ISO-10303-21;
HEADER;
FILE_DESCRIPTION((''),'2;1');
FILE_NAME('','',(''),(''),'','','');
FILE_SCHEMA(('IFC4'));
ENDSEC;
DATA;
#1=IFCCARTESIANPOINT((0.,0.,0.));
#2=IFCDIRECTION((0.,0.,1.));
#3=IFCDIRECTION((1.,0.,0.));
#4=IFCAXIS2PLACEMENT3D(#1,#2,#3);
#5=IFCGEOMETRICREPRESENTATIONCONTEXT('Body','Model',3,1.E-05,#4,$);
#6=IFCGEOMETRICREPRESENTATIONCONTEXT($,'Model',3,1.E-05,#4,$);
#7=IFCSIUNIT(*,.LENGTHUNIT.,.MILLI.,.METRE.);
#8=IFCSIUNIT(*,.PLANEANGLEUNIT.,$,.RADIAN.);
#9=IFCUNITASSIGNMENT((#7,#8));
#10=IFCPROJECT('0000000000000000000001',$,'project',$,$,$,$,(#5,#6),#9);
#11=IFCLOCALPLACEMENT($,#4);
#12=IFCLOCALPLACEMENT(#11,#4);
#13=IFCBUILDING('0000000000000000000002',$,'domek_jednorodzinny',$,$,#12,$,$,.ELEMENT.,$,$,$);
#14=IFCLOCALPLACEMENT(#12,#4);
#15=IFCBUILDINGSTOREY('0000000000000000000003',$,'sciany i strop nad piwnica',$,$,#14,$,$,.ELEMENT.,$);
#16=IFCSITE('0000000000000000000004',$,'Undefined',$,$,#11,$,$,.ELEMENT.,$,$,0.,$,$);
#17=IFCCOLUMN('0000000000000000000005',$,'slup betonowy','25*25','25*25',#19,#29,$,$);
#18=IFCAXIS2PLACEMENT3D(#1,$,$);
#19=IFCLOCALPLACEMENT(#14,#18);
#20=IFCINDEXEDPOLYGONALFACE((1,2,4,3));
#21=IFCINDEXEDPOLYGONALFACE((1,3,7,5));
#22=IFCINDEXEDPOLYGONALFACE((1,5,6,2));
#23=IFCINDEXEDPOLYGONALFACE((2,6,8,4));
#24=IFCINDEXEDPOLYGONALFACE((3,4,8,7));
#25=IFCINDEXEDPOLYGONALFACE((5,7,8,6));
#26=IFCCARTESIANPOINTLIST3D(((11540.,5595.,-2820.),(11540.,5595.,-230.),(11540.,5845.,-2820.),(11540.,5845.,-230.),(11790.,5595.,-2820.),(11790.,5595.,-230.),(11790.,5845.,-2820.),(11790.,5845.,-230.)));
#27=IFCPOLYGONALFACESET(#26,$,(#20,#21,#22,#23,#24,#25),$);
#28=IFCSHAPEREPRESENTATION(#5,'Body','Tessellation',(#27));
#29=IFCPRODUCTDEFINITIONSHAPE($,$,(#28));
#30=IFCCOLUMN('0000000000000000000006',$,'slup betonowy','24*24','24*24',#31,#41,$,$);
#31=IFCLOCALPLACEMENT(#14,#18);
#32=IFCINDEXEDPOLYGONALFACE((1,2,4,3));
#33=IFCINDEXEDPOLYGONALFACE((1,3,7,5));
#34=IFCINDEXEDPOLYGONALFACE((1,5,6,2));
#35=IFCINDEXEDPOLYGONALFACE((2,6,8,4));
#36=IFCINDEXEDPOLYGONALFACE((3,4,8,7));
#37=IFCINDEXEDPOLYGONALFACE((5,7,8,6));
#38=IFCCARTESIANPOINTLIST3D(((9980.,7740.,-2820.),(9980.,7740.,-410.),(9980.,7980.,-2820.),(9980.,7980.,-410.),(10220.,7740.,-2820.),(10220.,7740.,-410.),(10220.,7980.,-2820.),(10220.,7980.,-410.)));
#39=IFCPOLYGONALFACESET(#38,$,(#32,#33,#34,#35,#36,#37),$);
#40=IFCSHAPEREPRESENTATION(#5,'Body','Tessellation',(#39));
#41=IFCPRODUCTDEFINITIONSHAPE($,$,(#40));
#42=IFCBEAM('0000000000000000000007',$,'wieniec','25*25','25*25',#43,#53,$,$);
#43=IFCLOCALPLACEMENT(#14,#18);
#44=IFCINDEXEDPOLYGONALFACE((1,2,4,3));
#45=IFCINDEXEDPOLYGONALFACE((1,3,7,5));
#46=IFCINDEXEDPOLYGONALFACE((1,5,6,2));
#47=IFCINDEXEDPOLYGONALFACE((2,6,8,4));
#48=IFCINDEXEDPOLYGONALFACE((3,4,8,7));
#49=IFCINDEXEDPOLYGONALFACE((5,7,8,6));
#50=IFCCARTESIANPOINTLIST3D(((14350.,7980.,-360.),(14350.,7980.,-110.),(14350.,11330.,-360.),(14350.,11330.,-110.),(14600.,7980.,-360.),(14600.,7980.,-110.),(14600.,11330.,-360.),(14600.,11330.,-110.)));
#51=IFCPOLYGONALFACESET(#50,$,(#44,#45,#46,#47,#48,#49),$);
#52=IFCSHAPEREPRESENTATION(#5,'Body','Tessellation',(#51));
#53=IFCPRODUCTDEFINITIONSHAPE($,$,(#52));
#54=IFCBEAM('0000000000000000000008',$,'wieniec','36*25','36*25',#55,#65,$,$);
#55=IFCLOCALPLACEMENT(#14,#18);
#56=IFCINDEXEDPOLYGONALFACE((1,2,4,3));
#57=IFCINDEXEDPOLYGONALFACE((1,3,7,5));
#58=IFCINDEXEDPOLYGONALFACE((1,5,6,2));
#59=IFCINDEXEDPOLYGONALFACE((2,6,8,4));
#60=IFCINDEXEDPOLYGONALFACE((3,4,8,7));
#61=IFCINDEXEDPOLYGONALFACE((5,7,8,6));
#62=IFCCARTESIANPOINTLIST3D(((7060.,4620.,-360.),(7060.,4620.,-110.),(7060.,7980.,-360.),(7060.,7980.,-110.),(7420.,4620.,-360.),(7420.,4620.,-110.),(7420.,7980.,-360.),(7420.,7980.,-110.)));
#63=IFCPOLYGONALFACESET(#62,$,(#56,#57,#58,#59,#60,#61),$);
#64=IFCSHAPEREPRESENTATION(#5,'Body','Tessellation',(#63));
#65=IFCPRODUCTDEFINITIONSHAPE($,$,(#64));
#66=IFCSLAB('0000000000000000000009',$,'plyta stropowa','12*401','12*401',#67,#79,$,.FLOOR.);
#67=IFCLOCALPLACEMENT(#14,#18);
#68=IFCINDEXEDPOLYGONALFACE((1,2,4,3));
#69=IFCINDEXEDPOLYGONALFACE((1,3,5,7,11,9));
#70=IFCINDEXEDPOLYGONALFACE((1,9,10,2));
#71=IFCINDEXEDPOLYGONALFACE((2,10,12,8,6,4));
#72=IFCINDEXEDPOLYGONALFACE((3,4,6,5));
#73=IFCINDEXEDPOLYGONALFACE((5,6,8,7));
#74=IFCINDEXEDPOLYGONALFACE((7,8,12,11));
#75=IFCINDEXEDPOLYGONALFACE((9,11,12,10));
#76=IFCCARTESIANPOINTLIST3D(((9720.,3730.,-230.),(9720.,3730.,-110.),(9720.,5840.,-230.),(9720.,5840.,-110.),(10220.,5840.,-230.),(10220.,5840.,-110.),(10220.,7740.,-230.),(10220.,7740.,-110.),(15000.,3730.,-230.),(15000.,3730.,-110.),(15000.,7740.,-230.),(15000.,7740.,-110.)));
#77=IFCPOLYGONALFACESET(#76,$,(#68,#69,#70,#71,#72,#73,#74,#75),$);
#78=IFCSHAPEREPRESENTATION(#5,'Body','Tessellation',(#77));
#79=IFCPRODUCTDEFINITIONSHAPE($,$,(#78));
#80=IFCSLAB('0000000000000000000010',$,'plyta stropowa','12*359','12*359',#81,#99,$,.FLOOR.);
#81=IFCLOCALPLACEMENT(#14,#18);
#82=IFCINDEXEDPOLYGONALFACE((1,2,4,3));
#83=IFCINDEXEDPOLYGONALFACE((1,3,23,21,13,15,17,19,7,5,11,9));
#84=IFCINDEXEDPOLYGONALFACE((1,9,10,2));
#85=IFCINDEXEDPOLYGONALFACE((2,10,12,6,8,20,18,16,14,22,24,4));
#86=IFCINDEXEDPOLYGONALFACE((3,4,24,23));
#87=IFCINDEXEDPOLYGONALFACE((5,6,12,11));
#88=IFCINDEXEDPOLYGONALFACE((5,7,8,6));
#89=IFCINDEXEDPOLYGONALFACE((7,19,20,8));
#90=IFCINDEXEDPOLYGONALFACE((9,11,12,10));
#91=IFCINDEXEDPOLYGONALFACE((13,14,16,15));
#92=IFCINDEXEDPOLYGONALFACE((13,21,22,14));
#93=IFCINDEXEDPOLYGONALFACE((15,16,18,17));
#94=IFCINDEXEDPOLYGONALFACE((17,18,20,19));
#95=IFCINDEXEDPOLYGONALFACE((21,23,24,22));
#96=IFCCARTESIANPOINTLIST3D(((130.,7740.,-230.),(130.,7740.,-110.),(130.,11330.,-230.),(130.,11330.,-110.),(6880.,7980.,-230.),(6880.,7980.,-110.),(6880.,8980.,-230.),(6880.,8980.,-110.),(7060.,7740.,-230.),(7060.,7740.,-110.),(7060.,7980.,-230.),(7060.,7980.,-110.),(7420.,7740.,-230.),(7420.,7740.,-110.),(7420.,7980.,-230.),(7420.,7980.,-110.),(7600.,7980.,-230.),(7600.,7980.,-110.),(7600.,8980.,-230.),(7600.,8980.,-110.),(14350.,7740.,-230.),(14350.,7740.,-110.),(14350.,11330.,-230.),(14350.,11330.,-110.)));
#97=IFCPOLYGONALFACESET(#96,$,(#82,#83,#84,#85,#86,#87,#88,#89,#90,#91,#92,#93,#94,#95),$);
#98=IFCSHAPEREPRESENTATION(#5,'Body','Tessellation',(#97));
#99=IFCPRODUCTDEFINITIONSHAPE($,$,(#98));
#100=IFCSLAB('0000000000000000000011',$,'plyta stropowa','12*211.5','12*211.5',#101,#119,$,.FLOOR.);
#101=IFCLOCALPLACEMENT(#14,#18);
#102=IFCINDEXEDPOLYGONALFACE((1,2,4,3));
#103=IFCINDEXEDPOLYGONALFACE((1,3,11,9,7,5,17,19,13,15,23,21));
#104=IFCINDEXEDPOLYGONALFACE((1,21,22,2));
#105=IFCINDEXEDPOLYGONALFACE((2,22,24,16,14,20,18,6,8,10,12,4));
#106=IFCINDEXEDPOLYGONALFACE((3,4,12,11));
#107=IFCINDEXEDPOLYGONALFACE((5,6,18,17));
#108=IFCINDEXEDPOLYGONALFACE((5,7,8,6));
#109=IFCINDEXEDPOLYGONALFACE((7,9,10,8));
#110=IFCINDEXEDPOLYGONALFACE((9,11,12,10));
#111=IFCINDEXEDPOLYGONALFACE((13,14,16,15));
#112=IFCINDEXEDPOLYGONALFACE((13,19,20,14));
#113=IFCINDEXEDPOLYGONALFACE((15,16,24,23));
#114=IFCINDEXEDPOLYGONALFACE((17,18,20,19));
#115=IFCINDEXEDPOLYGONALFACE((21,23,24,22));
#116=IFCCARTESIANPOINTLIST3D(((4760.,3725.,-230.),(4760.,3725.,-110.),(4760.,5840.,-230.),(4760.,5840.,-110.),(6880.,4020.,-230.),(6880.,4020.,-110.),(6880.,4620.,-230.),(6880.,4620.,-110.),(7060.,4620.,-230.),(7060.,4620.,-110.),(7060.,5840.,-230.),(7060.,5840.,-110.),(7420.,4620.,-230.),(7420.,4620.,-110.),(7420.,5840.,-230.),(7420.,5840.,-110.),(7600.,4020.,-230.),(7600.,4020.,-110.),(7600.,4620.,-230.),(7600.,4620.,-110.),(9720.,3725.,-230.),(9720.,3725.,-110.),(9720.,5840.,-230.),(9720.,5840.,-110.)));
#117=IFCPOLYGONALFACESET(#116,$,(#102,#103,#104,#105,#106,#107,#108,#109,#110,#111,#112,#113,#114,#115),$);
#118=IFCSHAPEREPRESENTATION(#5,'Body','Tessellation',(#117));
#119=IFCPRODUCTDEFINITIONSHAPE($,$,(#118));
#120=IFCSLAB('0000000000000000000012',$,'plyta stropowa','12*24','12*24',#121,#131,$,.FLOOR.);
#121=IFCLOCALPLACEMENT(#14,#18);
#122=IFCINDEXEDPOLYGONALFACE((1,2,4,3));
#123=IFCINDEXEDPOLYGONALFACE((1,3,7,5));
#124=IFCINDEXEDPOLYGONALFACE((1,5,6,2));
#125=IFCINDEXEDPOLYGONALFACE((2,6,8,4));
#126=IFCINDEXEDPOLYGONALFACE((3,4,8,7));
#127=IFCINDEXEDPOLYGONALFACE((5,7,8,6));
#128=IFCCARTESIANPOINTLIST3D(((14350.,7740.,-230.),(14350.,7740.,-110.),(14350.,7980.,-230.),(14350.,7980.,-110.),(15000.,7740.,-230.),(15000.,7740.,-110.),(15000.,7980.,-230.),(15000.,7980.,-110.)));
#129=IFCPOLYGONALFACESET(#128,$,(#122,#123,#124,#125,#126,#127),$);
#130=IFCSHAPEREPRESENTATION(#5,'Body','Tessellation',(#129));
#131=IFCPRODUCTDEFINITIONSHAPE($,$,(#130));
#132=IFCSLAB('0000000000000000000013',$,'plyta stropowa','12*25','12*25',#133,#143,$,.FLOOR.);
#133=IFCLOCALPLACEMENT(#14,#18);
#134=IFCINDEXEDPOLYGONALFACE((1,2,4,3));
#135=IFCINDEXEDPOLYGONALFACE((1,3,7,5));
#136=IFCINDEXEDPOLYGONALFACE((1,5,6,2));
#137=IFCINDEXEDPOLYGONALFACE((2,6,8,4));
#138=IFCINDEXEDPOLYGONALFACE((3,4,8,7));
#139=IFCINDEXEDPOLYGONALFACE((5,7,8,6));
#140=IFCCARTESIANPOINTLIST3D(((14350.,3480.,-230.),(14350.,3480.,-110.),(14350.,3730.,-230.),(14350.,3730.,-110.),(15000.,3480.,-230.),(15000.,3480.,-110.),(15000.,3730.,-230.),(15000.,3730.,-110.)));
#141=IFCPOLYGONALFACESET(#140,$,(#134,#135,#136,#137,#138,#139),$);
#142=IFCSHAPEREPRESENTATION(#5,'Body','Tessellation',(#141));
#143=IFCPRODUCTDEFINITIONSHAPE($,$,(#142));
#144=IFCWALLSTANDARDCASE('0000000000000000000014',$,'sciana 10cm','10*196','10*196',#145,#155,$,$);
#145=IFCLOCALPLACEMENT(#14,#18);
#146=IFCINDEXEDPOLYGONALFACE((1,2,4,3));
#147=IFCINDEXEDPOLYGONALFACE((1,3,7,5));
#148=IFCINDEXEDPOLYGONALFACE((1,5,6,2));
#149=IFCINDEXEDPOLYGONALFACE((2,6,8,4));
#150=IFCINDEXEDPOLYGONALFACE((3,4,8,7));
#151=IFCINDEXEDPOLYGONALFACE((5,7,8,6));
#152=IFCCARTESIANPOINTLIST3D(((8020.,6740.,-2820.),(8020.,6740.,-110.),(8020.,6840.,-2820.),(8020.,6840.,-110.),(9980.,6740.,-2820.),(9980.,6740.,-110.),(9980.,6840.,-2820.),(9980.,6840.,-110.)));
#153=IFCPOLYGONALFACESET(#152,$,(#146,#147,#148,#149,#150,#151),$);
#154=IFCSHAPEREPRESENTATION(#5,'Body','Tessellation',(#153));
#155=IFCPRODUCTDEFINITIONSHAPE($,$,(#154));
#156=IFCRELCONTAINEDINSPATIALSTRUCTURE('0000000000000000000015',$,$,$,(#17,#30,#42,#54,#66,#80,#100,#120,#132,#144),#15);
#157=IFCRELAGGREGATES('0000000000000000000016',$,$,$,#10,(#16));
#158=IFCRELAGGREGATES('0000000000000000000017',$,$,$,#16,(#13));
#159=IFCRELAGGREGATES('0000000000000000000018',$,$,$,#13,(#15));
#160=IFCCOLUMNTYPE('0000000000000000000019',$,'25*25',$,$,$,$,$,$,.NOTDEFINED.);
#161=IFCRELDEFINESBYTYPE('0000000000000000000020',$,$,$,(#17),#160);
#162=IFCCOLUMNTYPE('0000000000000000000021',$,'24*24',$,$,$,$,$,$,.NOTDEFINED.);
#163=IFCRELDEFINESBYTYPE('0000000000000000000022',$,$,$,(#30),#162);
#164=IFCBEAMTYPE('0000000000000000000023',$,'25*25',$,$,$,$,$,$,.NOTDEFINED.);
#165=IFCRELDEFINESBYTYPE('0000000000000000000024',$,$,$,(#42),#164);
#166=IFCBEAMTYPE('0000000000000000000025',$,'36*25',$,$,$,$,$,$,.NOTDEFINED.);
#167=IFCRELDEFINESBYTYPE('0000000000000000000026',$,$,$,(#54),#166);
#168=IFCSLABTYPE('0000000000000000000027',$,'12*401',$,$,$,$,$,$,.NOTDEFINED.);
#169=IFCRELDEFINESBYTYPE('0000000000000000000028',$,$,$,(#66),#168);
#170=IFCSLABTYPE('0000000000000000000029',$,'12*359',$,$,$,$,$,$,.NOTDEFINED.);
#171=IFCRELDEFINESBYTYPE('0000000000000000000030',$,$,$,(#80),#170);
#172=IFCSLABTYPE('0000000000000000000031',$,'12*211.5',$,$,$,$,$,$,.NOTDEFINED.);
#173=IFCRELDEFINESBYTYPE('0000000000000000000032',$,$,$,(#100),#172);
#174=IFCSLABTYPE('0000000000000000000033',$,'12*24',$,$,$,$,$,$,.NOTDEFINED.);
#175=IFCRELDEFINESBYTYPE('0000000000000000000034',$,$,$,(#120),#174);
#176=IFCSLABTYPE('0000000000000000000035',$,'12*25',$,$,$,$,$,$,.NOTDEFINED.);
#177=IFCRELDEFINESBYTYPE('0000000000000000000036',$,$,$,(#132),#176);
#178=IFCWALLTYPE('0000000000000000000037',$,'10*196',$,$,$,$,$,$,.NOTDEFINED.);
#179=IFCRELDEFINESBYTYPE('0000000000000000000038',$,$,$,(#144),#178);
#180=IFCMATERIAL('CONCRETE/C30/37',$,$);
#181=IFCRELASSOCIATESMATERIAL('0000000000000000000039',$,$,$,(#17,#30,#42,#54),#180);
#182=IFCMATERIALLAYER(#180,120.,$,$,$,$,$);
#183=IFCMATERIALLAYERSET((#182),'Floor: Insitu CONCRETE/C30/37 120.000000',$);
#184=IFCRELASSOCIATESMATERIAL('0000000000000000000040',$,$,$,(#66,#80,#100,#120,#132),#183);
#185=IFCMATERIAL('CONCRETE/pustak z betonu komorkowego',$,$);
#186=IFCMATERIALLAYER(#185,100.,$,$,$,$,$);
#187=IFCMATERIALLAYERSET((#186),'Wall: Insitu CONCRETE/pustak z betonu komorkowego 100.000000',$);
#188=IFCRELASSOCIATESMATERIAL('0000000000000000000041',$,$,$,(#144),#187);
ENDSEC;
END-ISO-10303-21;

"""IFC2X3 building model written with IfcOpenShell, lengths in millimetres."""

from ifc_helpers import new_model, si_unit, frame, frame_2d, origin_with_axes, origin_2d_with_axis, place, context, project, spatial, polyline, rectangle, outline, extrude, material, layer, layer_set, layer_usage, type_object, element, save


model = new_model("IFC2X3")

# Units and contexts
model_context_1 = context("Model", 3, precision=1e-05, world=origin_with_axes(), identifier="Body")
model_context_2 = context("Model", 3, precision=1e-05, world=origin_with_axes())
ifc_project = project(units=[si_unit("LENGTHUNIT", "METRE", prefix="MILLI"), si_unit("PLANEANGLEUNIT", "RADIAN")], contexts=[model_context_1, model_context_2])

# Site, building, storey
site_placement = place(None, origin_with_axes())
site = spatial("IfcSite", under=ifc_project, at=site_placement, Name="Undefined", CompositionType="ELEMENT", RefElevation=0.0)
building_placement = place(site_placement, origin_with_axes())
building = spatial("IfcBuilding", under=site, at=building_placement, Name="domek_jednorodzinny", CompositionType="ELEMENT")
storey_placement = place(building_placement, origin_with_axes())
storey = spatial("IfcBuildingStorey", under=building, at=storey_placement, Name="sciany i strop nad piwnica", CompositionType="ELEMENT")

# Columns
ifc_material_1 = material(Name="CONCRETE/C30/37")
column_type_1 = type_object("IfcColumnType", Name="25*25", PredefinedType="NOTDEFINED")
column_1_placement = place(storey_placement, frame((11665.0, 5720.0, -2820.0), z_axis=(0.0, 0.0, 1.0), x_axis=(1.0, 0.0, 0.0)))
element("IfcColumn", 1, at=column_1_placement, inside=storey, type_object=column_type_1, material=ifc_material_1, Name="slup betonowy", Description="25*25", ObjectType="25*25", context=model_context_1, shape_type="SweptSolid", body=[
    extrude(rectangle(XDim=250.0, YDim=250.0, at=origin_2d_with_axis()), frame((0.0, 0.0, 2590.0), z_axis=(0.0, 0.000012, -1.0), x_axis=(-1.0, 0.0, 0.0)), (0.0, 0.0, 1.0), 2590.0),
])
column_type_2 = type_object("IfcColumnType", Name="24*24", PredefinedType="NOTDEFINED")
column_2_placement = place(storey_placement, frame((10100.0, 7860.0, -2820.0), z_axis=(0.0, 0.0, 1.0), x_axis=(1.0, 0.0, 0.0)))
element("IfcColumn", 2, at=column_2_placement, inside=storey, type_object=column_type_2, material=ifc_material_1, Name="slup betonowy", Description="24*24", ObjectType="24*24", context=model_context_1, shape_type="SweptSolid", body=[
    extrude(rectangle(XDim=240.0, YDim=240.0, at=origin_2d_with_axis()), frame((0.0, 0.0, 2410.0), z_axis=(0.000001, 0.000001, -1.0), x_axis=(-1.0, 0.0, 0.0)), (0.0, 0.0, 1.0), 2410.0),
])

# Beams
beam_type_1 = type_object("IfcBeamType", Name="25*25", PredefinedType="NOTDEFINED")
beam_1_placement = place(storey_placement, frame((14475.0, 7980.0, -235.0), z_axis=(0.0, 0.0, 1.0), x_axis=(0.0, 1.0, 0.0)))
element("IfcBeam", 3, at=beam_1_placement, inside=storey, type_object=beam_type_1, material=ifc_material_1, Name="wieniec", Description="25*25", ObjectType="25*25", context=model_context_1, shape_type="SweptSolid", body=[
    extrude(rectangle(XDim=250.0, YDim=250.0, at=origin_2d_with_axis()), frame((3350.0, 0.0, 0.0), z_axis=(-1.0, 0.0, 0.0), x_axis=(0.0, -1.0, 0.0)), (0.0, 0.0, 1.0), 3350.0),
])
beam_type_2 = type_object("IfcBeamType", Name="36*25", PredefinedType="NOTDEFINED")
beam_2_placement = place(storey_placement, frame((7240.0, 4620.0, -235.0), z_axis=(0.0, 0.0, 1.0), x_axis=(0.0, 1.0, 0.0)))
element("IfcBeam", 4, at=beam_2_placement, inside=storey, type_object=beam_type_2, material=ifc_material_1, Name="wieniec", Description="36*25", ObjectType="36*25", context=model_context_1, shape_type="SweptSolid", body=[
    extrude(rectangle(XDim=360.0, YDim=250.0, at=origin_2d_with_axis()), frame((3360.0, 0.0, 0.0), z_axis=(-1.0, 0.0, 0.0), x_axis=(0.0, -1.0, 0.0)), (0.0, 0.0, 1.0), 3360.0),
])

# Slab, opening
ifc_layer_1 = layer(ifc_material_1, 120.0)
ifc_layer_set_1 = layer_set([ifc_layer_1], Name="Floor: Insitu CONCRETE/C30/37 120.000000")
ifc_layer_usage_1 = layer_usage(ifc_layer_set_1, "AXIS3", "POSITIVE", -60.0)
slab_type_1 = type_object("IfcSlabType", Name="12*401", PredefinedType="NOTDEFINED")
slab_1_placement = place(storey_placement, frame((15000.0, 7740.0, -170.0), z_axis=(0.0, 0.0, 1.0), x_axis=(-1.0, 0.0, 0.0)))
slab_1 = element("IfcSlab", 5, at=slab_1_placement, inside=storey, type_object=slab_type_1, material=ifc_layer_usage_1, Name="plyta stropowa", Description="12*401", ObjectType="12*401", PredefinedType="FLOOR", context=model_context_1, shape_type="SweptSolid", body=[
    extrude(outline(polyline([(0.0, 0.0), (5280.0, 0.0), (5280.0, 4010.0), (0.0, 4010.0), (0.0, 0.0)])), frame((0.0, 0.0, -60.0), z_axis=(0.0, 0.0, 1.0), x_axis=(1.0, 0.0, 0.0)), (0.0, 0.0, 1.0), 120.0),
])
opening_1_placement = place(storey_placement, frame((15000.0, 7740.0, -170.0), z_axis=(0.0, 0.0, 1.0), x_axis=(-1.0, 0.0, 0.0)))
element("IfcOpeningElement", 6, at=opening_1_placement, cuts=slab_1, ObjectType="Recess", context=model_context_1, shape_type="SweptSolid", body=[
    extrude(outline(polyline([(0.0, 0.0), (500.0, 0.0), (500.0, 1900.0), (0.0, 1900.0), (0.0, 0.0)])), frame((4780.0, 1900.0, 62.5), z_axis=(0.000001, 0.000001, -1.0), x_axis=(1.0, 0.0, 0.0)), (0.0, 0.0, 1.0), 125.0),
])

# Slabs, openings
ifc_layer_usage_2 = layer_usage(ifc_layer_set_1, "AXIS3", "POSITIVE", -60.0)
slab_type_2 = type_object("IfcSlabType", Name="12*359", PredefinedType="NOTDEFINED")
slab_2_placement = place(storey_placement, frame((14350.0, 11330.0, -170.0), z_axis=(0.0, 0.0, 1.0), x_axis=(-1.0, 0.0, 0.0)))
slab_2 = element("IfcSlab", 7, at=slab_2_placement, inside=storey, type_object=slab_type_2, material=ifc_layer_usage_2, Name="plyta stropowa", Description="12*359", ObjectType="12*359", PredefinedType="FLOOR", context=model_context_1, shape_type="SweptSolid", body=[
    extrude(outline(polyline([(0.0, 0.0), (14220.0, 0.0), (14220.0, 3590.0), (0.0, 3590.0), (0.0, 0.0)])), frame((0.0, 0.0, -60.0), z_axis=(0.0, 0.0, 1.0), x_axis=(1.0, 0.0, 0.0)), (0.0, 0.0, 1.0), 120.0),
])
opening_2_placement = place(storey_placement, frame((14350.0, 11330.0, -170.0), z_axis=(0.0, 0.0, 1.0), x_axis=(-1.0, 0.0, 0.0)))
element("IfcOpeningElement", 8, at=opening_2_placement, cuts=slab_2, ObjectType="Recess", context=model_context_1, shape_type="SweptSolid", body=[
    extrude(outline(polyline([(0.0, 0.0), (1000.0, 0.0), (1000.0, 720.0), (0.0, 720.0), (0.0, 0.0)])), frame((6750.0, 2350.0, 62.5), z_axis=(0.000001, 0.000001, -1.0), x_axis=(0.0, 1.0, 0.0)), (0.0, 0.0, 1.0), 125.0),
])
opening_3_placement = place(storey_placement, frame((14350.0, 11330.0, -170.0), z_axis=(0.0, 0.0, 1.0), x_axis=(-1.0, 0.0, 0.0)))
element("IfcOpeningElement", 9, at=opening_3_placement, cuts=slab_2, ObjectType="Recess", context=model_context_1, shape_type="SweptSolid", body=[
    extrude(outline(polyline([(0.0, 0.0), (290.0, 0.0), (290.0, 360.0), (0.0, 360.0), (0.0, 0.0)])), frame((7290.0, 3610.0, 112.5), z_axis=(0.000001, 0.000001, -1.0), x_axis=(0.0, -1.0, 0.0)), (0.0, 0.0, 1.0), 225.0),
])
ifc_layer_usage_3 = layer_usage(ifc_layer_set_1, "AXIS3", "POSITIVE", -60.0)
slab_type_3 = type_object("IfcSlabType", Name="12*211.5", PredefinedType="NOTDEFINED")
slab_3_placement = place(storey_placement, frame((9720.0, 5840.0, -170.0), z_axis=(0.0, 0.0, 1.0), x_axis=(-1.0, 0.0, 0.0)))
slab_3 = element("IfcSlab", 10, at=slab_3_placement, inside=storey, type_object=slab_type_3, material=ifc_layer_usage_3, Name="plyta stropowa", Description="12*211.5", ObjectType="12*211.5", PredefinedType="FLOOR", context=model_context_1, shape_type="SweptSolid", body=[
    extrude(outline(polyline([(0.0, 0.0), (4960.0, 0.0), (4960.0, 2115.0), (0.0, 2115.0), (0.0, 0.0)])), frame((0.0, 0.0, -60.0), z_axis=(0.0, 0.0, 1.0), x_axis=(1.0, 0.0, 0.0)), (0.0, 0.0, 1.0), 120.0),
])
opening_4_placement = place(storey_placement, frame((9720.0, 5840.0, -170.0), z_axis=(0.0, 0.0, 1.0), x_axis=(-1.0, 0.0, 0.0)))
element("IfcOpeningElement", 11, at=opening_4_placement, cuts=slab_3, ObjectType="Recess", context=model_context_1, shape_type="SweptSolid", body=[
    extrude(outline(polyline([(0.0, 0.0), (720.0, 0.0), (720.0, 600.0), (0.0, 600.0), (0.0, 0.0)])), frame((2840.0, 1220.0, 62.5), z_axis=(0.000001, 0.000001, -1.0), x_axis=(-1.0, 0.000046, 0.0)), (0.0, 0.0, 1.0), 125.0),
])
opening_5_placement = place(storey_placement, frame((9720.0, 5840.0, -170.0), z_axis=(0.0, 0.0, 1.0), x_axis=(-1.0, 0.0, 0.0)))
element("IfcOpeningElement", 12, at=opening_5_placement, cuts=slab_3, ObjectType="Recess", context=model_context_1, shape_type="SweptSolid", body=[
    extrude(outline(polyline([(0.0, 0.0), (1220.0, 0.0), (1220.0, 360.0), (0.0, 360.1), (0.0, 0.0)])), frame((2300.0, 1220.0, -62.5), z_axis=(0.0, 0.0, 1.0), x_axis=(0.0, -1.0, 0.0)), (0.0, 0.0, 1.0), 125.0),
])

# Slabs
ifc_layer_usage_4 = layer_usage(ifc_layer_set_1, "AXIS3", "POSITIVE", -60.0)
slab_type_4 = type_object("IfcSlabType", Name="12*24", PredefinedType="NOTDEFINED")
slab_4_placement = place(storey_placement, frame((15000.0, 7980.0, -170.0), z_axis=(0.0, 0.0, 1.0), x_axis=(-1.0, 0.0, 0.0)))
element("IfcSlab", 13, at=slab_4_placement, inside=storey, type_object=slab_type_4, material=ifc_layer_usage_4, Name="plyta stropowa", Description="12*24", ObjectType="12*24", PredefinedType="FLOOR", context=model_context_1, shape_type="SweptSolid", body=[
    extrude(outline(polyline([(0.0, 0.0), (650.0, 0.0), (650.0, 240.0), (0.0, 240.0), (0.0, 0.0)])), frame((0.0, 0.0, -60.0), z_axis=(0.0, 0.0, 1.0), x_axis=(1.0, 0.0, 0.0)), (0.0, 0.0, 1.0), 120.0),
])
ifc_layer_usage_5 = layer_usage(ifc_layer_set_1, "AXIS3", "POSITIVE", -60.0)
slab_type_5 = type_object("IfcSlabType", Name="12*25", PredefinedType="NOTDEFINED")
slab_5_placement = place(storey_placement, frame((15000.0, 3730.0, -170.0), z_axis=(0.0, 0.0, 1.0), x_axis=(-1.0, 0.0, 0.0)))
element("IfcSlab", 14, at=slab_5_placement, inside=storey, type_object=slab_type_5, material=ifc_layer_usage_5, Name="plyta stropowa", Description="12*25", ObjectType="12*25", PredefinedType="FLOOR", context=model_context_1, shape_type="SweptSolid", body=[
    extrude(outline(polyline([(0.0, 0.0), (650.0, 0.0), (650.0, 250.0), (0.0, 250.0), (0.0, 0.0)])), frame((0.0, 0.0, -60.0), z_axis=(0.0, 0.0, 1.0), x_axis=(1.0, 0.0, 0.0)), (0.0, 0.0, 1.0), 120.0),
])

# Wall
ifc_material_2 = material(Name="CONCRETE/pustak z betonu komorkowego")
ifc_layer_2 = layer(ifc_material_2, 100.0)
ifc_layer_set_2 = layer_set([ifc_layer_2], Name="Wall: Insitu CONCRETE/pustak z betonu komorkowego 100.000000")
ifc_layer_usage_6 = layer_usage(ifc_layer_set_2, "AXIS2", "POSITIVE", -50.0)
wall_type_1 = type_object("IfcWallType", Name="10*196", PredefinedType="NOTDEFINED")
wall_1_placement = place(storey_placement, frame((9980.0, 6790.0, -2820.0), z_axis=(0.0, 0.0, 1.0), x_axis=(-1.0, 0.0, 0.0)))
element("IfcWallStandardCase", 15, at=wall_1_placement, inside=storey, type_object=wall_type_1, material=ifc_layer_usage_6, Name="sciana 10cm", Description="10*196", ObjectType="10*196", context=model_context_1, shape_type="SweptSolid", body=[
    extrude(rectangle(XDim=1960.0, YDim=100.0, at=frame_2d((0.0, 980.0), x_axis=(0.0, -1.0))), frame((0.0, 0.0, 0.0), z_axis=(0.0, 0.0, 1.0), x_axis=(0.0, -1.0, 0.0)), (0.0, 0.0, 1.0), 2710.0),
])

save(model, "model.ifc")
